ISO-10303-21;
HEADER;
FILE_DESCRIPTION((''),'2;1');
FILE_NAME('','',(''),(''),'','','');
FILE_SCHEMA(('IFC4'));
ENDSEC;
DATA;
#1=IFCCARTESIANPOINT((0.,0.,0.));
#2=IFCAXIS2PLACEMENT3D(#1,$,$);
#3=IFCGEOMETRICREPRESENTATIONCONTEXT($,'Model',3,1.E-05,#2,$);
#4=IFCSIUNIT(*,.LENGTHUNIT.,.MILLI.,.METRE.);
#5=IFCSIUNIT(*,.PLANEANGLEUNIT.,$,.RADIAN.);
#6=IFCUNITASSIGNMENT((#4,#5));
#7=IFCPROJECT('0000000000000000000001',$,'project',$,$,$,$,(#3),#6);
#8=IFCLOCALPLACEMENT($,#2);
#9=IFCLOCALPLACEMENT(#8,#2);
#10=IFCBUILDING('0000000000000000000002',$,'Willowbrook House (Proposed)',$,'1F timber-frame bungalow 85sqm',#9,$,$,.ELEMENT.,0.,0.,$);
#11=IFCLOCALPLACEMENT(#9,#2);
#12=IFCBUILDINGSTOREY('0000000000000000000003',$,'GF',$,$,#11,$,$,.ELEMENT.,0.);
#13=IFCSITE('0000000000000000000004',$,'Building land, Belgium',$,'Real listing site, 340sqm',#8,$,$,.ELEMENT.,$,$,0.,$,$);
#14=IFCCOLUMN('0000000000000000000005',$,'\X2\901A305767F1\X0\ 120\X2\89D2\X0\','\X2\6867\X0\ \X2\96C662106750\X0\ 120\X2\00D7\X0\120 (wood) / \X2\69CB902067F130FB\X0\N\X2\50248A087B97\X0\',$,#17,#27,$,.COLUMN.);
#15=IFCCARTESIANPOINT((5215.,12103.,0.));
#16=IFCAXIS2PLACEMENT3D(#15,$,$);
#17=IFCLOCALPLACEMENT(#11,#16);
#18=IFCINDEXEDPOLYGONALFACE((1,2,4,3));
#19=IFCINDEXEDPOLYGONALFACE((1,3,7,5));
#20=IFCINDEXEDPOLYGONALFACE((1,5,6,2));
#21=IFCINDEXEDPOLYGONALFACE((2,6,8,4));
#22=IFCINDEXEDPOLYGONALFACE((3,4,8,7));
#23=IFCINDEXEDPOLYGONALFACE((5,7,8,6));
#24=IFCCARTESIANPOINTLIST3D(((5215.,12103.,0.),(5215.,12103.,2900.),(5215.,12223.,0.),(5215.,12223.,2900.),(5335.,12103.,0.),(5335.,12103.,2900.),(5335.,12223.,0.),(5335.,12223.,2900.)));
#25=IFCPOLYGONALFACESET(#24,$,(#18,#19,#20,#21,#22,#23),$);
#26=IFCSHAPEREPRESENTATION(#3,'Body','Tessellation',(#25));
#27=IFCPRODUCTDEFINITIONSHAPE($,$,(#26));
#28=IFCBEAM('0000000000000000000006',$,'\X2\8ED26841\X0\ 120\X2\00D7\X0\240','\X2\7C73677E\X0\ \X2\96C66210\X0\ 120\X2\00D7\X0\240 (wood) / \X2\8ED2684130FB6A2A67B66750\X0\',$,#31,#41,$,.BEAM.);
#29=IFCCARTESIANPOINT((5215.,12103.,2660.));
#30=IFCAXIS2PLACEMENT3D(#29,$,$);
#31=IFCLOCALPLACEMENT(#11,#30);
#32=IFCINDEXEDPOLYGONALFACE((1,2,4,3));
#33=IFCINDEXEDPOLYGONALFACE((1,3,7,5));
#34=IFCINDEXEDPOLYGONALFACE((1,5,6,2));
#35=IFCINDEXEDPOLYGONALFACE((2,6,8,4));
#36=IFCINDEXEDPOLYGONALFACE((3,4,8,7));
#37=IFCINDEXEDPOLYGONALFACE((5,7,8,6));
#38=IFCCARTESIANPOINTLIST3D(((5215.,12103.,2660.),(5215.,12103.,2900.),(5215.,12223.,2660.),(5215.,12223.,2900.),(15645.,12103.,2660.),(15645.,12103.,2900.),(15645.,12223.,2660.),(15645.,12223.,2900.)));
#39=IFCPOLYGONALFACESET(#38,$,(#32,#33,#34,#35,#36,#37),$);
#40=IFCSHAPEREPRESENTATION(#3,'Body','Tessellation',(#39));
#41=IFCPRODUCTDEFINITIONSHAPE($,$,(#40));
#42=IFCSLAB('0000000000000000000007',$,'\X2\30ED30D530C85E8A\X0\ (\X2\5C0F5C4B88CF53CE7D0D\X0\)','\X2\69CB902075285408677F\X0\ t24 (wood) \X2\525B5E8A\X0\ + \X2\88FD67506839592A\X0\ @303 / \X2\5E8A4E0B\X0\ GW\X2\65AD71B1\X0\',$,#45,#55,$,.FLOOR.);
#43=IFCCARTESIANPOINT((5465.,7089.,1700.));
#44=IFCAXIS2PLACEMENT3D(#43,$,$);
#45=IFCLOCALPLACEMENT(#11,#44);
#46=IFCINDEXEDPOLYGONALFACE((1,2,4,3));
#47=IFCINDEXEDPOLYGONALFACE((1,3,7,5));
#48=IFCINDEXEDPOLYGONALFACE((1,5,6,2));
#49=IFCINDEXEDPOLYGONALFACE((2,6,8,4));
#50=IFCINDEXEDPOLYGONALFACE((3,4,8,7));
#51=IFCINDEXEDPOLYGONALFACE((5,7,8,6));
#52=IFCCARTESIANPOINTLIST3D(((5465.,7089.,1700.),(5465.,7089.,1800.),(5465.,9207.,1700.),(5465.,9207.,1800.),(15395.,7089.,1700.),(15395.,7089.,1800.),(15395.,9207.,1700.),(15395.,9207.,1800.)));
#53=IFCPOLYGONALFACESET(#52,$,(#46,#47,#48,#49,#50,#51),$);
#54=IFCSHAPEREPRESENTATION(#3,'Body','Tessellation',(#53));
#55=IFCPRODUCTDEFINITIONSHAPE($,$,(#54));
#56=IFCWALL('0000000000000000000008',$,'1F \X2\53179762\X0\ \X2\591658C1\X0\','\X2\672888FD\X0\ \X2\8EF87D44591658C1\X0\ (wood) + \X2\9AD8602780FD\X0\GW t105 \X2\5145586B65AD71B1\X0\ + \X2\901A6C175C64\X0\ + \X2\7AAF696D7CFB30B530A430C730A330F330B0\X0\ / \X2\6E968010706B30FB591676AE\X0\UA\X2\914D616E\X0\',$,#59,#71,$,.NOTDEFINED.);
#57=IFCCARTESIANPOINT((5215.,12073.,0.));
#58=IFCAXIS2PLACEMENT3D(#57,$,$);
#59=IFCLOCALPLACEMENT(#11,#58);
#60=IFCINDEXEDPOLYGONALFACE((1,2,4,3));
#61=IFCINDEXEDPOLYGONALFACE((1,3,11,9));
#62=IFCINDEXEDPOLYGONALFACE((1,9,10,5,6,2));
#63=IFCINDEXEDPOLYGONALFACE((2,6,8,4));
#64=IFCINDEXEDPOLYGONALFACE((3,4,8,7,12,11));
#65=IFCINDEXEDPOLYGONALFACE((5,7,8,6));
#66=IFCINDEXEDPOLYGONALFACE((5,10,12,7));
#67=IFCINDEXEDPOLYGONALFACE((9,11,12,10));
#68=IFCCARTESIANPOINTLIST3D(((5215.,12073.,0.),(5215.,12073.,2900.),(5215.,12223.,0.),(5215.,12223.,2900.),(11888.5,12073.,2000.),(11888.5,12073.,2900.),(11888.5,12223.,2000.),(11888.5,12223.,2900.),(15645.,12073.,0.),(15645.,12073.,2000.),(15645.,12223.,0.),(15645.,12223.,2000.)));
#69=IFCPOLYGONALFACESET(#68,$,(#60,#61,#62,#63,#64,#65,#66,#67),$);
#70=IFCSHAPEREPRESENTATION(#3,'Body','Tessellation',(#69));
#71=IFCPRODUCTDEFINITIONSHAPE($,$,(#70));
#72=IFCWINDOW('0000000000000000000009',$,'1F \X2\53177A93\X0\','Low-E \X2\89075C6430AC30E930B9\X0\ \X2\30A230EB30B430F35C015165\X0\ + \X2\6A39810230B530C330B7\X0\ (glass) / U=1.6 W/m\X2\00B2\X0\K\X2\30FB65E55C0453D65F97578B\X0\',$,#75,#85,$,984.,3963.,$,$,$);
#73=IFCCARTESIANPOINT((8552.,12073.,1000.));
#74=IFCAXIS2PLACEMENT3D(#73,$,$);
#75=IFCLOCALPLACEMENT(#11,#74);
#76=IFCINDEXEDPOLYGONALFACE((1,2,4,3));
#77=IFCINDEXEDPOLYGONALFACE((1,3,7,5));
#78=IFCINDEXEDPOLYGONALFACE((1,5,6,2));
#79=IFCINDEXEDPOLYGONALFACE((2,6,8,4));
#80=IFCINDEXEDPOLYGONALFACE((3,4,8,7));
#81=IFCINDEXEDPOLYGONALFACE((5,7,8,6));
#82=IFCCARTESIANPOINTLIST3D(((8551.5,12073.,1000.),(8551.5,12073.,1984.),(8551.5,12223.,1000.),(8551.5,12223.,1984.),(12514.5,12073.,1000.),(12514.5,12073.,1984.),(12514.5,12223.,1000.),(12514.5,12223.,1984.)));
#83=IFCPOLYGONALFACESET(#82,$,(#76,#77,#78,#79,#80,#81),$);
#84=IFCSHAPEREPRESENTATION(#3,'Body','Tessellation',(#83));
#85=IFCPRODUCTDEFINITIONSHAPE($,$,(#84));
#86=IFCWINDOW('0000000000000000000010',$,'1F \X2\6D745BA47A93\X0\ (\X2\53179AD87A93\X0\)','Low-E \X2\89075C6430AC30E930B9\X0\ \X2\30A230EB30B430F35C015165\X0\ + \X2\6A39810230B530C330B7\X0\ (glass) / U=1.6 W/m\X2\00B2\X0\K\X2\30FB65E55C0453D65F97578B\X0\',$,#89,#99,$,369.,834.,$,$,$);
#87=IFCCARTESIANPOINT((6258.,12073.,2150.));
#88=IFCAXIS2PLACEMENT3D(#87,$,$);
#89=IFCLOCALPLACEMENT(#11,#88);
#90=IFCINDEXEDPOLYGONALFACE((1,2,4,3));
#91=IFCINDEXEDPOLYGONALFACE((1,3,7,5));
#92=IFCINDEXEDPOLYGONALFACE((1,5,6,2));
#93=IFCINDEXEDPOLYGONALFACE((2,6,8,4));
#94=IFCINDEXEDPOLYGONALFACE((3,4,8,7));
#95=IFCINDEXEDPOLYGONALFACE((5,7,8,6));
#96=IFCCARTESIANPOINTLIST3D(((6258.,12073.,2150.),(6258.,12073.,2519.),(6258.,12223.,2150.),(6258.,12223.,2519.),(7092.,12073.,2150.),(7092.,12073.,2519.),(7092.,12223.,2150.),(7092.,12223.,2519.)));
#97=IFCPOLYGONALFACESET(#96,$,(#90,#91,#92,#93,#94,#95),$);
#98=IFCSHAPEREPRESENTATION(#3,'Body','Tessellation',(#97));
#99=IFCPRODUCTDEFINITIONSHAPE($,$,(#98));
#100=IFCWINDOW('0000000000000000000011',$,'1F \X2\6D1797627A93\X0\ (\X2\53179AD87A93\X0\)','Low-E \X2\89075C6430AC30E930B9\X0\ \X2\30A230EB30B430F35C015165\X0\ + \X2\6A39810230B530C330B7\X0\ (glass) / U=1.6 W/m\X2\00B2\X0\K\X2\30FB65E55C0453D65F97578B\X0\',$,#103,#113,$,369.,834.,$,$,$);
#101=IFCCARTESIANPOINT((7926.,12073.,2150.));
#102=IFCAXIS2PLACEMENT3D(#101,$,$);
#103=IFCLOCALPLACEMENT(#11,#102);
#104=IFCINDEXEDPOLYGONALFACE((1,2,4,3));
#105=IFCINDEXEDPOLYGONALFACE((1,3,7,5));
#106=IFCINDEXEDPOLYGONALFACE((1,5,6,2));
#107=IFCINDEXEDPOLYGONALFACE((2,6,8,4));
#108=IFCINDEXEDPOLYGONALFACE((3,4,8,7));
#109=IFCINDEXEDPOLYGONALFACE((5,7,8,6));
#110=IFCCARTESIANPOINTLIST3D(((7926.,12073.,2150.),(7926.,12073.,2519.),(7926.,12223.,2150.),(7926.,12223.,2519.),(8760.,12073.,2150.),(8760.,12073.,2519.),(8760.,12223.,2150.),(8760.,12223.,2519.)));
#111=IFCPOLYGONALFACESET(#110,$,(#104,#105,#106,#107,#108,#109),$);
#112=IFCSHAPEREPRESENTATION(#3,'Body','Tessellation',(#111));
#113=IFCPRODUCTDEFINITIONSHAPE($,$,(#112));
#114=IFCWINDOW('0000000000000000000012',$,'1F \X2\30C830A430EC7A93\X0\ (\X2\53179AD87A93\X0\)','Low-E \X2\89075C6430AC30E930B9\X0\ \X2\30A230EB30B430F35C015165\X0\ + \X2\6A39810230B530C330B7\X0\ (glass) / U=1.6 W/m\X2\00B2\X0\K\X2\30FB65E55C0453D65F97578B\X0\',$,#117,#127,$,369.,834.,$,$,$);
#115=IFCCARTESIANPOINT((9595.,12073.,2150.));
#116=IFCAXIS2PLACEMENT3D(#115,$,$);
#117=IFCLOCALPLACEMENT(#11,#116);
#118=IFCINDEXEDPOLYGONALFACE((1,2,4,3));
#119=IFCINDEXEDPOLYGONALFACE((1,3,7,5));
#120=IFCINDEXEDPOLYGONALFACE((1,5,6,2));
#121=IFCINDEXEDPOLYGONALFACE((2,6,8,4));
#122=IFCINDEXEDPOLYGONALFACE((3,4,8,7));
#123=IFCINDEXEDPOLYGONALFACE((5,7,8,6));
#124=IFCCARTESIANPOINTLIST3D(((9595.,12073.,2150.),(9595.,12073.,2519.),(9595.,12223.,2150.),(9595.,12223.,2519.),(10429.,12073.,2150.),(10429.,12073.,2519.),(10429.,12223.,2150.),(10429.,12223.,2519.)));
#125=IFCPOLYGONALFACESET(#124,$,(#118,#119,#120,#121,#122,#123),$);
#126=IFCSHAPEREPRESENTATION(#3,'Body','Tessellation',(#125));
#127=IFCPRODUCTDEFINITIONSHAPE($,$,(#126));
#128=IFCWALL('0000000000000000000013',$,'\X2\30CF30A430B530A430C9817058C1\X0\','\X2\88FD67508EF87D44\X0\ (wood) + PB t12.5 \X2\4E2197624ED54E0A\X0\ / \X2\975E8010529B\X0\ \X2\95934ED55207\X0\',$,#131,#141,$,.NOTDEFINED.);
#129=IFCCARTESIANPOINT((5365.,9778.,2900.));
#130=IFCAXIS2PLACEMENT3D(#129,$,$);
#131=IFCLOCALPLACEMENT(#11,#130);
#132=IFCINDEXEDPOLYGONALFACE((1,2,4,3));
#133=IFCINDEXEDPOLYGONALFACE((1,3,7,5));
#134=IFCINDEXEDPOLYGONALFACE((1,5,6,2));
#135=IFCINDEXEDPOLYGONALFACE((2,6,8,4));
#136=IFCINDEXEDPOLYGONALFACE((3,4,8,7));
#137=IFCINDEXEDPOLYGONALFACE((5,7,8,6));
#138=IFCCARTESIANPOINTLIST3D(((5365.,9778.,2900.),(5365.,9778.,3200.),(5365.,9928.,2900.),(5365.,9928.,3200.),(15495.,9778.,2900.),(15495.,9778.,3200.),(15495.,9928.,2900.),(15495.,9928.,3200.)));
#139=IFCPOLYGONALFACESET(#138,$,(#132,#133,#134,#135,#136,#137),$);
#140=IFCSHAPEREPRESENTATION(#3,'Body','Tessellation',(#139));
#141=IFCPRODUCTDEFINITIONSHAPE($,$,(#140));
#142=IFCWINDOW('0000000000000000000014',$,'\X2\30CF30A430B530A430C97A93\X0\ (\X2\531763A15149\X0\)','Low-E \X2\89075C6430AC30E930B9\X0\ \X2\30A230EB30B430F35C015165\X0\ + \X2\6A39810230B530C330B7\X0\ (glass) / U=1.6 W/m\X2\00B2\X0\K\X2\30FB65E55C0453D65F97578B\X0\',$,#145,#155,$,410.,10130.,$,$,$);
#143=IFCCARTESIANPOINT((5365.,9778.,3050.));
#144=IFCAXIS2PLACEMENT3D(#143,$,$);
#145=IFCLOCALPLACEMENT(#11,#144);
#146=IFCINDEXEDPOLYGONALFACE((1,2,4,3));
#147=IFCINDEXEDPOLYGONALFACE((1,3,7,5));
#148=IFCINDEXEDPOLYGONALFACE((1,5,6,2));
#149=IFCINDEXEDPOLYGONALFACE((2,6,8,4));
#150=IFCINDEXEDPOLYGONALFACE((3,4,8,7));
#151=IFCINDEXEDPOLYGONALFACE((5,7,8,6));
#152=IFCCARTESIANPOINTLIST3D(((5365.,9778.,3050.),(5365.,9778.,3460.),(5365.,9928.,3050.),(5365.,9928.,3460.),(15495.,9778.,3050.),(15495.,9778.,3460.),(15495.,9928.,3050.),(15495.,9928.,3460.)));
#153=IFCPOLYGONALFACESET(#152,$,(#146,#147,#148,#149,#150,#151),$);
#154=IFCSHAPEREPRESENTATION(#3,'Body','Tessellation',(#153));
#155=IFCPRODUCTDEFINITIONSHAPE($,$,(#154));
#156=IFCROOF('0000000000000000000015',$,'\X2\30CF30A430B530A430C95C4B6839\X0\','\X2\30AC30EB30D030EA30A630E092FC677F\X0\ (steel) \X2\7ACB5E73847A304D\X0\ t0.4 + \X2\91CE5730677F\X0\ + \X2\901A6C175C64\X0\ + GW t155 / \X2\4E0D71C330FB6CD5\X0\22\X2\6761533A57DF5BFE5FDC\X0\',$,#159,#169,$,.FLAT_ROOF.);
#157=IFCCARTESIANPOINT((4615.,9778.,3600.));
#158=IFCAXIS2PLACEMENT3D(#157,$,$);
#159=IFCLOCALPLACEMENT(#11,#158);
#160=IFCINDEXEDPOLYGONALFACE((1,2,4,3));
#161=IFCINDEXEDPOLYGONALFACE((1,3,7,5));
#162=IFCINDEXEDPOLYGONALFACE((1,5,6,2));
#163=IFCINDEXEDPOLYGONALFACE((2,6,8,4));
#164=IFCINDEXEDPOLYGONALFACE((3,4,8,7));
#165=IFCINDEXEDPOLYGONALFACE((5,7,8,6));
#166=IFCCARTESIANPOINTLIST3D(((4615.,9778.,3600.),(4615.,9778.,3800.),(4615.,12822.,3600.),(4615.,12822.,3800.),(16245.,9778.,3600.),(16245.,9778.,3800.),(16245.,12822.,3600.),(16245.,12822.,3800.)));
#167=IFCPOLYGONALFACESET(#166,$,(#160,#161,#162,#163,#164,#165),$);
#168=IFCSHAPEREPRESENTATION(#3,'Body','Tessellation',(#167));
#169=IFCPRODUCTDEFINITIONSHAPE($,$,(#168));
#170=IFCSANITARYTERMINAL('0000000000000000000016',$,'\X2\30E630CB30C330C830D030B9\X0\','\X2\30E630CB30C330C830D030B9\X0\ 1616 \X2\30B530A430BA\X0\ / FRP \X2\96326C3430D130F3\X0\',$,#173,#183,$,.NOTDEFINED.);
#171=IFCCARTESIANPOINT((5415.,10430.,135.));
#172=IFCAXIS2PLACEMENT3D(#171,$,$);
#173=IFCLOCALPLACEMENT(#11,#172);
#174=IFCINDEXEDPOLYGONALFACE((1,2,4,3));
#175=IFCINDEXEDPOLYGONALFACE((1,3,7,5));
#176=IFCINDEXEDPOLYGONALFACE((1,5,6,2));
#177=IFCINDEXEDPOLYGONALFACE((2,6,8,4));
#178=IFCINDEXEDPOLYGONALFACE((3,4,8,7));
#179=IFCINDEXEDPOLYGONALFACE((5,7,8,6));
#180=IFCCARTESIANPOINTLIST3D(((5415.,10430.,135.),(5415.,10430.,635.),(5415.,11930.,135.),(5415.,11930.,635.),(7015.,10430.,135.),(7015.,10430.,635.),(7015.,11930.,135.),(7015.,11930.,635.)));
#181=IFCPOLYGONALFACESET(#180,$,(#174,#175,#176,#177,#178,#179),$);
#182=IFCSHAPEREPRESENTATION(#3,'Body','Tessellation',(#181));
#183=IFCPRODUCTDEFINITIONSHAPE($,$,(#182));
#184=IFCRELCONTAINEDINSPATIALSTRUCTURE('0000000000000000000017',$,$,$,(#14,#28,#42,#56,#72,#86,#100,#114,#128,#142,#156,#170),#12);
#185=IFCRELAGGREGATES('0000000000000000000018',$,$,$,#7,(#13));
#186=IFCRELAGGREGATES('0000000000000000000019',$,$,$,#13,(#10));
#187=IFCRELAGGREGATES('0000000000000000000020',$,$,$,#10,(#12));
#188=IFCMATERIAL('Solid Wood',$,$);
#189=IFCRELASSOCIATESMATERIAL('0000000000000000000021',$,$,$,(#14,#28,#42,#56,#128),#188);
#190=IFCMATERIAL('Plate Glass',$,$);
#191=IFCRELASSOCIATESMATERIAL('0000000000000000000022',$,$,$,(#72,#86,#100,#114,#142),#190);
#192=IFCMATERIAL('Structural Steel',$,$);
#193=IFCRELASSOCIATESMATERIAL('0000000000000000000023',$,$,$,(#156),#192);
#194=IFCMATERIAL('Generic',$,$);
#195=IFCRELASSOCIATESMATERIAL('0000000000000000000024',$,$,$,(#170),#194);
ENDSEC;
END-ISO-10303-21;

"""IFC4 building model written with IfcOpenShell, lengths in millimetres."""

from ifc_helpers import new_model, si_unit, frame, frame_2d, origin, place, context, project, spatial, rectangle, extrude, material, element, fill, save


model = new_model("IFC4")

# Units and contexts
model_context = context("Model", 3, precision=1e-05, world=origin())
ifc_project = project(units=[si_unit("LENGTHUNIT", "METRE", prefix="MILLI"), si_unit("PLANEANGLEUNIT", "RADIAN")], contexts=[model_context])

# Site, building, storey
site_placement = place(None, origin())
site = spatial("IfcSite", under=ifc_project, at=site_placement, Name="Building land, Belgium", ObjectType="Real listing site, 340sqm", CompositionType="ELEMENT", RefElevation=0.0)
building_placement = place(site_placement, origin())
building = spatial("IfcBuilding", under=site, at=building_placement, Name="Willowbrook House (Proposed)", ObjectType="1F timber-frame bungalow 85sqm", CompositionType="ELEMENT", ElevationOfRefHeight=0.0, ElevationOfTerrain=0.0)
storey_placement = place(building_placement, origin())
storey = spatial("IfcBuildingStorey", under=building, at=storey_placement, Name="GF", CompositionType="ELEMENT", Elevation=0.0)

# Column
ifc_material_1 = material(Name="Solid Wood")
column_1_placement = place(storey_placement, frame((5215.0, 12103.0, 0.0)))
element("IfcColumn", 1, at=column_1_placement, inside=storey, material=ifc_material_1, Name="通し柱 120角", Description="桧 集成材 120×120 (wood) / 構造柱・N値計算", PredefinedType="COLUMN", context=model_context, shape_type="SweptSolid", body=[
    extrude(rectangle(XDim=120.0, YDim=120.0, at=frame_2d((60.0, 60.0))), frame((5215.0, 12103.0, 0.0)), (0.0, 0.0, 1.0), 2900.0),
])

# Beam
beam_1_placement = place(storey_placement, frame((5215.0, 12103.0, 2660.0)))
element("IfcBeam", 2, at=beam_1_placement, inside=storey, material=ifc_material_1, Name="軒桁 120×240", Description="米松 集成 120×240 (wood) / 軒桁・横架材", PredefinedType="BEAM", context=model_context, shape_type="SweptSolid", body=[
    extrude(rectangle(XDim=10430.0, YDim=120.0, at=frame_2d((5215.0, 60.0))), frame((5215.0, 12103.0, 2660.0)), (0.0, 0.0, 1.0), 240.0),
])

# Slab
slab_placement = place(storey_placement, frame((5465.0, 7089.0, 1700.0)))
element("IfcSlab", 3, at=slab_placement, inside=storey, material=ifc_material_1, Name="ロフト床 (小屋裏収納)", Description="構造用合板 t24 (wood) 剛床 + 製材根太 @303 / 床下 GW断熱", PredefinedType="FLOOR", context=model_context, shape_type="SweptSolid", body=[
    extrude(rectangle(XDim=9930.0, YDim=2118.0, at=frame_2d((4965.0, 1059.0))), frame((5465.0, 7089.0, 1700.0)), (0.0, 0.0, 1.0), 100.0),
])

# Wall, openings, windows
wall_1_placement = place(storey_placement, frame((5215.0, 12073.0, 0.0)))
wall_1 = element("IfcWall", 4, at=wall_1_placement, inside=storey, material=ifc_material_1, Name="1F 北面 外壁", Description="木製 軸組外壁 (wood) + 高性能GW t105 充填断熱 + 通気層 + 窯業系サイディング / 準耐火・外皮UA配慮", PredefinedType="NOTDEFINED", context=model_context, shape_type="SweptSolid", body=[
    extrude(rectangle(XDim=10430.0, YDim=150.0, at=frame_2d((5215.0, 75.0))), frame((5215.0, 12073.0, 0.0)), (0.0, 0.0, 1.0), 2900.0),
])
opening_1_placement = place(storey_placement, frame((8552.0, 12073.0, 1000.0)))
opening_1 = element("IfcOpeningElement", 5, at=opening_1_placement, cuts=wall_1, PredefinedType="NOTDEFINED", context=model_context, shape_type="SweptSolid", body=[
    extrude(rectangle(XDim=3963.0, YDim=150.0, at=frame_2d((1981.0, 75.0))), frame((8552.0, 12073.0, 1000.0)), (0.0, 0.0, 1.0), 984.0),
])
opening_2_placement = place(storey_placement, frame((6258.0, 12073.0, 2150.0)))
opening_2 = element("IfcOpeningElement", 6, at=opening_2_placement, cuts=wall_1, PredefinedType="NOTDEFINED", context=model_context, shape_type="SweptSolid", body=[
    extrude(rectangle(XDim=834.0, YDim=150.0, at=frame_2d((417.0, 75.0))), frame((6258.0, 12073.0, 2150.0)), (0.0, 0.0, 1.0), 369.0),
])
opening_3_placement = place(storey_placement, frame((7926.0, 12073.0, 2150.0)))
opening_3 = element("IfcOpeningElement", 7, at=opening_3_placement, cuts=wall_1, PredefinedType="NOTDEFINED", context=model_context, shape_type="SweptSolid", body=[
    extrude(rectangle(XDim=834.0, YDim=150.0, at=frame_2d((417.0, 75.0))), frame((7926.0, 12073.0, 2150.0)), (0.0, 0.0, 1.0), 369.0),
])
opening_4_placement = place(storey_placement, frame((9595.0, 12073.0, 2150.0)))
opening_4 = element("IfcOpeningElement", 8, at=opening_4_placement, cuts=wall_1, PredefinedType="NOTDEFINED", context=model_context, shape_type="SweptSolid", body=[
    extrude(rectangle(XDim=834.0, YDim=150.0, at=frame_2d((417.0, 75.0))), frame((9595.0, 12073.0, 2150.0)), (0.0, 0.0, 1.0), 369.0),
])
ifc_material_2 = material(Name="Plate Glass")
window_1_placement = place(storey_placement, frame((8552.0, 12073.0, 1000.0)))
window_1 = element("IfcWindow", 9, at=window_1_placement, inside=storey, material=ifc_material_2, Name="1F 北窓", Description="Low-E 複層ガラス アルゴン封入 + 樹脂サッシ (glass) / U=1.6 W/m²K・日射取得型", OverallHeight=984.0, OverallWidth=3963.0, context=model_context, shape_type="SweptSolid", body=[
    extrude(rectangle(XDim=3963.0, YDim=150.0, at=frame_2d((1981.0, 75.0))), frame((8552.0, 12073.0, 1000.0)), (0.0, 0.0, 1.0), 984.0),
])
fill(opening_1, window_1)
window_2_placement = place(storey_placement, frame((6258.0, 12073.0, 2150.0)))
window_2 = element("IfcWindow", 10, at=window_2_placement, inside=storey, material=ifc_material_2, Name="1F 浴室窓 (北高窓)", Description="Low-E 複層ガラス アルゴン封入 + 樹脂サッシ (glass) / U=1.6 W/m²K・日射取得型", OverallHeight=369.0, OverallWidth=834.0, context=model_context, shape_type="SweptSolid", body=[
    extrude(rectangle(XDim=834.0, YDim=150.0, at=frame_2d((417.0, 75.0))), frame((6258.0, 12073.0, 2150.0)), (0.0, 0.0, 1.0), 369.0),
])
fill(opening_2, window_2)
window_3_placement = place(storey_placement, frame((7926.0, 12073.0, 2150.0)))
window_3 = element("IfcWindow", 11, at=window_3_placement, inside=storey, material=ifc_material_2, Name="1F 洗面窓 (北高窓)", Description="Low-E 複層ガラス アルゴン封入 + 樹脂サッシ (glass) / U=1.6 W/m²K・日射取得型", OverallHeight=369.0, OverallWidth=834.0, context=model_context, shape_type="SweptSolid", body=[
    extrude(rectangle(XDim=834.0, YDim=150.0, at=frame_2d((417.0, 75.0))), frame((7926.0, 12073.0, 2150.0)), (0.0, 0.0, 1.0), 369.0),
])
fill(opening_3, window_3)
window_4_placement = place(storey_placement, frame((9595.0, 12073.0, 2150.0)))
window_4 = element("IfcWindow", 12, at=window_4_placement, inside=storey, material=ifc_material_2, Name="1F トイレ窓 (北高窓)", Description="Low-E 複層ガラス アルゴン封入 + 樹脂サッシ (glass) / U=1.6 W/m²K・日射取得型", OverallHeight=369.0, OverallWidth=834.0, context=model_context, shape_type="SweptSolid", body=[
    extrude(rectangle(XDim=834.0, YDim=150.0, at=frame_2d((417.0, 75.0))), frame((9595.0, 12073.0, 2150.0)), (0.0, 0.0, 1.0), 369.0),
])
fill(opening_4, window_4)

# Wall, opening, window
wall_2_placement = place(storey_placement, frame((5365.0, 9778.0, 2900.0)))
wall_2 = element("IfcWall", 13, at=wall_2_placement, inside=storey, material=ifc_material_1, Name="ハイサイド腰壁", Description="製材軸組 (wood) + PB t12.5 両面仕上 / 非耐力 間仕切", PredefinedType="NOTDEFINED", context=model_context, shape_type="SweptSolid", body=[
    extrude(rectangle(XDim=10130.0, YDim=150.0, at=frame_2d((5065.0, 75.0))), frame((5365.0, 9778.0, 2900.0)), (0.0, 0.0, 1.0), 700.0),
])
opening_5_placement = place(storey_placement, frame((5365.0, 9778.0, 3050.0)))
opening_5 = element("IfcOpeningElement", 14, at=opening_5_placement, cuts=wall_2, PredefinedType="NOTDEFINED", context=model_context, shape_type="SweptSolid", body=[
    extrude(rectangle(XDim=10130.0, YDim=150.0, at=frame_2d((5065.0, 75.0))), frame((5365.0, 9778.0, 3050.0)), (0.0, 0.0, 1.0), 410.0),
])
window_5_placement = place(storey_placement, frame((5365.0, 9778.0, 3050.0)))
window_5 = element("IfcWindow", 15, at=window_5_placement, inside=storey, material=ifc_material_2, Name="ハイサイド窓 (北採光)", Description="Low-E 複層ガラス アルゴン封入 + 樹脂サッシ (glass) / U=1.6 W/m²K・日射取得型", OverallHeight=410.0, OverallWidth=10130.0, context=model_context, shape_type="SweptSolid", body=[
    extrude(rectangle(XDim=10130.0, YDim=150.0, at=frame_2d((5065.0, 75.0))), frame((5365.0, 9778.0, 3050.0)), (0.0, 0.0, 1.0), 410.0),
])
fill(opening_5, window_5)

# Roof
ifc_material_3 = material(Name="Structural Steel")
roof_placement = place(storey_placement, frame((4615.0, 9778.0, 3600.0)))
element("IfcRoof", 16, at=roof_placement, inside=storey, material=ifc_material_3, Name="ハイサイド屋根", Description="ガルバリウム鋼板 (steel) 立平葺き t0.4 + 野地板 + 通気層 + GW t155 / 不燃・法22条区域対応", PredefinedType="FLAT_ROOF", context=model_context, shape_type="SweptSolid", body=[
    extrude(rectangle(XDim=11630.0, YDim=3044.0, at=frame_2d((5815.0, 1522.0))), frame((4615.0, 9778.0, 3600.0)), (0.0, 0.0, 1.0), 200.0),
])

# Sanitary terminal
ifc_material_4 = material(Name="Generic")
sanitary_terminal_placement = place(storey_placement, frame((5415.0, 10430.0, 135.0)))
element("IfcSanitaryTerminal", 17, at=sanitary_terminal_placement, inside=storey, material=ifc_material_4, Name="ユニットバス", Description="ユニットバス 1616 サイズ / FRP 防水パン", PredefinedType="NOTDEFINED", context=model_context, shape_type="SweptSolid", body=[
    extrude(rectangle(XDim=1600.0, YDim=1500.0, at=frame_2d((800.0, 750.0))), frame((5415.0, 10430.0, 135.0)), (0.0, 0.0, 1.0), 500.0),
])

save(model, "model.ifc")
